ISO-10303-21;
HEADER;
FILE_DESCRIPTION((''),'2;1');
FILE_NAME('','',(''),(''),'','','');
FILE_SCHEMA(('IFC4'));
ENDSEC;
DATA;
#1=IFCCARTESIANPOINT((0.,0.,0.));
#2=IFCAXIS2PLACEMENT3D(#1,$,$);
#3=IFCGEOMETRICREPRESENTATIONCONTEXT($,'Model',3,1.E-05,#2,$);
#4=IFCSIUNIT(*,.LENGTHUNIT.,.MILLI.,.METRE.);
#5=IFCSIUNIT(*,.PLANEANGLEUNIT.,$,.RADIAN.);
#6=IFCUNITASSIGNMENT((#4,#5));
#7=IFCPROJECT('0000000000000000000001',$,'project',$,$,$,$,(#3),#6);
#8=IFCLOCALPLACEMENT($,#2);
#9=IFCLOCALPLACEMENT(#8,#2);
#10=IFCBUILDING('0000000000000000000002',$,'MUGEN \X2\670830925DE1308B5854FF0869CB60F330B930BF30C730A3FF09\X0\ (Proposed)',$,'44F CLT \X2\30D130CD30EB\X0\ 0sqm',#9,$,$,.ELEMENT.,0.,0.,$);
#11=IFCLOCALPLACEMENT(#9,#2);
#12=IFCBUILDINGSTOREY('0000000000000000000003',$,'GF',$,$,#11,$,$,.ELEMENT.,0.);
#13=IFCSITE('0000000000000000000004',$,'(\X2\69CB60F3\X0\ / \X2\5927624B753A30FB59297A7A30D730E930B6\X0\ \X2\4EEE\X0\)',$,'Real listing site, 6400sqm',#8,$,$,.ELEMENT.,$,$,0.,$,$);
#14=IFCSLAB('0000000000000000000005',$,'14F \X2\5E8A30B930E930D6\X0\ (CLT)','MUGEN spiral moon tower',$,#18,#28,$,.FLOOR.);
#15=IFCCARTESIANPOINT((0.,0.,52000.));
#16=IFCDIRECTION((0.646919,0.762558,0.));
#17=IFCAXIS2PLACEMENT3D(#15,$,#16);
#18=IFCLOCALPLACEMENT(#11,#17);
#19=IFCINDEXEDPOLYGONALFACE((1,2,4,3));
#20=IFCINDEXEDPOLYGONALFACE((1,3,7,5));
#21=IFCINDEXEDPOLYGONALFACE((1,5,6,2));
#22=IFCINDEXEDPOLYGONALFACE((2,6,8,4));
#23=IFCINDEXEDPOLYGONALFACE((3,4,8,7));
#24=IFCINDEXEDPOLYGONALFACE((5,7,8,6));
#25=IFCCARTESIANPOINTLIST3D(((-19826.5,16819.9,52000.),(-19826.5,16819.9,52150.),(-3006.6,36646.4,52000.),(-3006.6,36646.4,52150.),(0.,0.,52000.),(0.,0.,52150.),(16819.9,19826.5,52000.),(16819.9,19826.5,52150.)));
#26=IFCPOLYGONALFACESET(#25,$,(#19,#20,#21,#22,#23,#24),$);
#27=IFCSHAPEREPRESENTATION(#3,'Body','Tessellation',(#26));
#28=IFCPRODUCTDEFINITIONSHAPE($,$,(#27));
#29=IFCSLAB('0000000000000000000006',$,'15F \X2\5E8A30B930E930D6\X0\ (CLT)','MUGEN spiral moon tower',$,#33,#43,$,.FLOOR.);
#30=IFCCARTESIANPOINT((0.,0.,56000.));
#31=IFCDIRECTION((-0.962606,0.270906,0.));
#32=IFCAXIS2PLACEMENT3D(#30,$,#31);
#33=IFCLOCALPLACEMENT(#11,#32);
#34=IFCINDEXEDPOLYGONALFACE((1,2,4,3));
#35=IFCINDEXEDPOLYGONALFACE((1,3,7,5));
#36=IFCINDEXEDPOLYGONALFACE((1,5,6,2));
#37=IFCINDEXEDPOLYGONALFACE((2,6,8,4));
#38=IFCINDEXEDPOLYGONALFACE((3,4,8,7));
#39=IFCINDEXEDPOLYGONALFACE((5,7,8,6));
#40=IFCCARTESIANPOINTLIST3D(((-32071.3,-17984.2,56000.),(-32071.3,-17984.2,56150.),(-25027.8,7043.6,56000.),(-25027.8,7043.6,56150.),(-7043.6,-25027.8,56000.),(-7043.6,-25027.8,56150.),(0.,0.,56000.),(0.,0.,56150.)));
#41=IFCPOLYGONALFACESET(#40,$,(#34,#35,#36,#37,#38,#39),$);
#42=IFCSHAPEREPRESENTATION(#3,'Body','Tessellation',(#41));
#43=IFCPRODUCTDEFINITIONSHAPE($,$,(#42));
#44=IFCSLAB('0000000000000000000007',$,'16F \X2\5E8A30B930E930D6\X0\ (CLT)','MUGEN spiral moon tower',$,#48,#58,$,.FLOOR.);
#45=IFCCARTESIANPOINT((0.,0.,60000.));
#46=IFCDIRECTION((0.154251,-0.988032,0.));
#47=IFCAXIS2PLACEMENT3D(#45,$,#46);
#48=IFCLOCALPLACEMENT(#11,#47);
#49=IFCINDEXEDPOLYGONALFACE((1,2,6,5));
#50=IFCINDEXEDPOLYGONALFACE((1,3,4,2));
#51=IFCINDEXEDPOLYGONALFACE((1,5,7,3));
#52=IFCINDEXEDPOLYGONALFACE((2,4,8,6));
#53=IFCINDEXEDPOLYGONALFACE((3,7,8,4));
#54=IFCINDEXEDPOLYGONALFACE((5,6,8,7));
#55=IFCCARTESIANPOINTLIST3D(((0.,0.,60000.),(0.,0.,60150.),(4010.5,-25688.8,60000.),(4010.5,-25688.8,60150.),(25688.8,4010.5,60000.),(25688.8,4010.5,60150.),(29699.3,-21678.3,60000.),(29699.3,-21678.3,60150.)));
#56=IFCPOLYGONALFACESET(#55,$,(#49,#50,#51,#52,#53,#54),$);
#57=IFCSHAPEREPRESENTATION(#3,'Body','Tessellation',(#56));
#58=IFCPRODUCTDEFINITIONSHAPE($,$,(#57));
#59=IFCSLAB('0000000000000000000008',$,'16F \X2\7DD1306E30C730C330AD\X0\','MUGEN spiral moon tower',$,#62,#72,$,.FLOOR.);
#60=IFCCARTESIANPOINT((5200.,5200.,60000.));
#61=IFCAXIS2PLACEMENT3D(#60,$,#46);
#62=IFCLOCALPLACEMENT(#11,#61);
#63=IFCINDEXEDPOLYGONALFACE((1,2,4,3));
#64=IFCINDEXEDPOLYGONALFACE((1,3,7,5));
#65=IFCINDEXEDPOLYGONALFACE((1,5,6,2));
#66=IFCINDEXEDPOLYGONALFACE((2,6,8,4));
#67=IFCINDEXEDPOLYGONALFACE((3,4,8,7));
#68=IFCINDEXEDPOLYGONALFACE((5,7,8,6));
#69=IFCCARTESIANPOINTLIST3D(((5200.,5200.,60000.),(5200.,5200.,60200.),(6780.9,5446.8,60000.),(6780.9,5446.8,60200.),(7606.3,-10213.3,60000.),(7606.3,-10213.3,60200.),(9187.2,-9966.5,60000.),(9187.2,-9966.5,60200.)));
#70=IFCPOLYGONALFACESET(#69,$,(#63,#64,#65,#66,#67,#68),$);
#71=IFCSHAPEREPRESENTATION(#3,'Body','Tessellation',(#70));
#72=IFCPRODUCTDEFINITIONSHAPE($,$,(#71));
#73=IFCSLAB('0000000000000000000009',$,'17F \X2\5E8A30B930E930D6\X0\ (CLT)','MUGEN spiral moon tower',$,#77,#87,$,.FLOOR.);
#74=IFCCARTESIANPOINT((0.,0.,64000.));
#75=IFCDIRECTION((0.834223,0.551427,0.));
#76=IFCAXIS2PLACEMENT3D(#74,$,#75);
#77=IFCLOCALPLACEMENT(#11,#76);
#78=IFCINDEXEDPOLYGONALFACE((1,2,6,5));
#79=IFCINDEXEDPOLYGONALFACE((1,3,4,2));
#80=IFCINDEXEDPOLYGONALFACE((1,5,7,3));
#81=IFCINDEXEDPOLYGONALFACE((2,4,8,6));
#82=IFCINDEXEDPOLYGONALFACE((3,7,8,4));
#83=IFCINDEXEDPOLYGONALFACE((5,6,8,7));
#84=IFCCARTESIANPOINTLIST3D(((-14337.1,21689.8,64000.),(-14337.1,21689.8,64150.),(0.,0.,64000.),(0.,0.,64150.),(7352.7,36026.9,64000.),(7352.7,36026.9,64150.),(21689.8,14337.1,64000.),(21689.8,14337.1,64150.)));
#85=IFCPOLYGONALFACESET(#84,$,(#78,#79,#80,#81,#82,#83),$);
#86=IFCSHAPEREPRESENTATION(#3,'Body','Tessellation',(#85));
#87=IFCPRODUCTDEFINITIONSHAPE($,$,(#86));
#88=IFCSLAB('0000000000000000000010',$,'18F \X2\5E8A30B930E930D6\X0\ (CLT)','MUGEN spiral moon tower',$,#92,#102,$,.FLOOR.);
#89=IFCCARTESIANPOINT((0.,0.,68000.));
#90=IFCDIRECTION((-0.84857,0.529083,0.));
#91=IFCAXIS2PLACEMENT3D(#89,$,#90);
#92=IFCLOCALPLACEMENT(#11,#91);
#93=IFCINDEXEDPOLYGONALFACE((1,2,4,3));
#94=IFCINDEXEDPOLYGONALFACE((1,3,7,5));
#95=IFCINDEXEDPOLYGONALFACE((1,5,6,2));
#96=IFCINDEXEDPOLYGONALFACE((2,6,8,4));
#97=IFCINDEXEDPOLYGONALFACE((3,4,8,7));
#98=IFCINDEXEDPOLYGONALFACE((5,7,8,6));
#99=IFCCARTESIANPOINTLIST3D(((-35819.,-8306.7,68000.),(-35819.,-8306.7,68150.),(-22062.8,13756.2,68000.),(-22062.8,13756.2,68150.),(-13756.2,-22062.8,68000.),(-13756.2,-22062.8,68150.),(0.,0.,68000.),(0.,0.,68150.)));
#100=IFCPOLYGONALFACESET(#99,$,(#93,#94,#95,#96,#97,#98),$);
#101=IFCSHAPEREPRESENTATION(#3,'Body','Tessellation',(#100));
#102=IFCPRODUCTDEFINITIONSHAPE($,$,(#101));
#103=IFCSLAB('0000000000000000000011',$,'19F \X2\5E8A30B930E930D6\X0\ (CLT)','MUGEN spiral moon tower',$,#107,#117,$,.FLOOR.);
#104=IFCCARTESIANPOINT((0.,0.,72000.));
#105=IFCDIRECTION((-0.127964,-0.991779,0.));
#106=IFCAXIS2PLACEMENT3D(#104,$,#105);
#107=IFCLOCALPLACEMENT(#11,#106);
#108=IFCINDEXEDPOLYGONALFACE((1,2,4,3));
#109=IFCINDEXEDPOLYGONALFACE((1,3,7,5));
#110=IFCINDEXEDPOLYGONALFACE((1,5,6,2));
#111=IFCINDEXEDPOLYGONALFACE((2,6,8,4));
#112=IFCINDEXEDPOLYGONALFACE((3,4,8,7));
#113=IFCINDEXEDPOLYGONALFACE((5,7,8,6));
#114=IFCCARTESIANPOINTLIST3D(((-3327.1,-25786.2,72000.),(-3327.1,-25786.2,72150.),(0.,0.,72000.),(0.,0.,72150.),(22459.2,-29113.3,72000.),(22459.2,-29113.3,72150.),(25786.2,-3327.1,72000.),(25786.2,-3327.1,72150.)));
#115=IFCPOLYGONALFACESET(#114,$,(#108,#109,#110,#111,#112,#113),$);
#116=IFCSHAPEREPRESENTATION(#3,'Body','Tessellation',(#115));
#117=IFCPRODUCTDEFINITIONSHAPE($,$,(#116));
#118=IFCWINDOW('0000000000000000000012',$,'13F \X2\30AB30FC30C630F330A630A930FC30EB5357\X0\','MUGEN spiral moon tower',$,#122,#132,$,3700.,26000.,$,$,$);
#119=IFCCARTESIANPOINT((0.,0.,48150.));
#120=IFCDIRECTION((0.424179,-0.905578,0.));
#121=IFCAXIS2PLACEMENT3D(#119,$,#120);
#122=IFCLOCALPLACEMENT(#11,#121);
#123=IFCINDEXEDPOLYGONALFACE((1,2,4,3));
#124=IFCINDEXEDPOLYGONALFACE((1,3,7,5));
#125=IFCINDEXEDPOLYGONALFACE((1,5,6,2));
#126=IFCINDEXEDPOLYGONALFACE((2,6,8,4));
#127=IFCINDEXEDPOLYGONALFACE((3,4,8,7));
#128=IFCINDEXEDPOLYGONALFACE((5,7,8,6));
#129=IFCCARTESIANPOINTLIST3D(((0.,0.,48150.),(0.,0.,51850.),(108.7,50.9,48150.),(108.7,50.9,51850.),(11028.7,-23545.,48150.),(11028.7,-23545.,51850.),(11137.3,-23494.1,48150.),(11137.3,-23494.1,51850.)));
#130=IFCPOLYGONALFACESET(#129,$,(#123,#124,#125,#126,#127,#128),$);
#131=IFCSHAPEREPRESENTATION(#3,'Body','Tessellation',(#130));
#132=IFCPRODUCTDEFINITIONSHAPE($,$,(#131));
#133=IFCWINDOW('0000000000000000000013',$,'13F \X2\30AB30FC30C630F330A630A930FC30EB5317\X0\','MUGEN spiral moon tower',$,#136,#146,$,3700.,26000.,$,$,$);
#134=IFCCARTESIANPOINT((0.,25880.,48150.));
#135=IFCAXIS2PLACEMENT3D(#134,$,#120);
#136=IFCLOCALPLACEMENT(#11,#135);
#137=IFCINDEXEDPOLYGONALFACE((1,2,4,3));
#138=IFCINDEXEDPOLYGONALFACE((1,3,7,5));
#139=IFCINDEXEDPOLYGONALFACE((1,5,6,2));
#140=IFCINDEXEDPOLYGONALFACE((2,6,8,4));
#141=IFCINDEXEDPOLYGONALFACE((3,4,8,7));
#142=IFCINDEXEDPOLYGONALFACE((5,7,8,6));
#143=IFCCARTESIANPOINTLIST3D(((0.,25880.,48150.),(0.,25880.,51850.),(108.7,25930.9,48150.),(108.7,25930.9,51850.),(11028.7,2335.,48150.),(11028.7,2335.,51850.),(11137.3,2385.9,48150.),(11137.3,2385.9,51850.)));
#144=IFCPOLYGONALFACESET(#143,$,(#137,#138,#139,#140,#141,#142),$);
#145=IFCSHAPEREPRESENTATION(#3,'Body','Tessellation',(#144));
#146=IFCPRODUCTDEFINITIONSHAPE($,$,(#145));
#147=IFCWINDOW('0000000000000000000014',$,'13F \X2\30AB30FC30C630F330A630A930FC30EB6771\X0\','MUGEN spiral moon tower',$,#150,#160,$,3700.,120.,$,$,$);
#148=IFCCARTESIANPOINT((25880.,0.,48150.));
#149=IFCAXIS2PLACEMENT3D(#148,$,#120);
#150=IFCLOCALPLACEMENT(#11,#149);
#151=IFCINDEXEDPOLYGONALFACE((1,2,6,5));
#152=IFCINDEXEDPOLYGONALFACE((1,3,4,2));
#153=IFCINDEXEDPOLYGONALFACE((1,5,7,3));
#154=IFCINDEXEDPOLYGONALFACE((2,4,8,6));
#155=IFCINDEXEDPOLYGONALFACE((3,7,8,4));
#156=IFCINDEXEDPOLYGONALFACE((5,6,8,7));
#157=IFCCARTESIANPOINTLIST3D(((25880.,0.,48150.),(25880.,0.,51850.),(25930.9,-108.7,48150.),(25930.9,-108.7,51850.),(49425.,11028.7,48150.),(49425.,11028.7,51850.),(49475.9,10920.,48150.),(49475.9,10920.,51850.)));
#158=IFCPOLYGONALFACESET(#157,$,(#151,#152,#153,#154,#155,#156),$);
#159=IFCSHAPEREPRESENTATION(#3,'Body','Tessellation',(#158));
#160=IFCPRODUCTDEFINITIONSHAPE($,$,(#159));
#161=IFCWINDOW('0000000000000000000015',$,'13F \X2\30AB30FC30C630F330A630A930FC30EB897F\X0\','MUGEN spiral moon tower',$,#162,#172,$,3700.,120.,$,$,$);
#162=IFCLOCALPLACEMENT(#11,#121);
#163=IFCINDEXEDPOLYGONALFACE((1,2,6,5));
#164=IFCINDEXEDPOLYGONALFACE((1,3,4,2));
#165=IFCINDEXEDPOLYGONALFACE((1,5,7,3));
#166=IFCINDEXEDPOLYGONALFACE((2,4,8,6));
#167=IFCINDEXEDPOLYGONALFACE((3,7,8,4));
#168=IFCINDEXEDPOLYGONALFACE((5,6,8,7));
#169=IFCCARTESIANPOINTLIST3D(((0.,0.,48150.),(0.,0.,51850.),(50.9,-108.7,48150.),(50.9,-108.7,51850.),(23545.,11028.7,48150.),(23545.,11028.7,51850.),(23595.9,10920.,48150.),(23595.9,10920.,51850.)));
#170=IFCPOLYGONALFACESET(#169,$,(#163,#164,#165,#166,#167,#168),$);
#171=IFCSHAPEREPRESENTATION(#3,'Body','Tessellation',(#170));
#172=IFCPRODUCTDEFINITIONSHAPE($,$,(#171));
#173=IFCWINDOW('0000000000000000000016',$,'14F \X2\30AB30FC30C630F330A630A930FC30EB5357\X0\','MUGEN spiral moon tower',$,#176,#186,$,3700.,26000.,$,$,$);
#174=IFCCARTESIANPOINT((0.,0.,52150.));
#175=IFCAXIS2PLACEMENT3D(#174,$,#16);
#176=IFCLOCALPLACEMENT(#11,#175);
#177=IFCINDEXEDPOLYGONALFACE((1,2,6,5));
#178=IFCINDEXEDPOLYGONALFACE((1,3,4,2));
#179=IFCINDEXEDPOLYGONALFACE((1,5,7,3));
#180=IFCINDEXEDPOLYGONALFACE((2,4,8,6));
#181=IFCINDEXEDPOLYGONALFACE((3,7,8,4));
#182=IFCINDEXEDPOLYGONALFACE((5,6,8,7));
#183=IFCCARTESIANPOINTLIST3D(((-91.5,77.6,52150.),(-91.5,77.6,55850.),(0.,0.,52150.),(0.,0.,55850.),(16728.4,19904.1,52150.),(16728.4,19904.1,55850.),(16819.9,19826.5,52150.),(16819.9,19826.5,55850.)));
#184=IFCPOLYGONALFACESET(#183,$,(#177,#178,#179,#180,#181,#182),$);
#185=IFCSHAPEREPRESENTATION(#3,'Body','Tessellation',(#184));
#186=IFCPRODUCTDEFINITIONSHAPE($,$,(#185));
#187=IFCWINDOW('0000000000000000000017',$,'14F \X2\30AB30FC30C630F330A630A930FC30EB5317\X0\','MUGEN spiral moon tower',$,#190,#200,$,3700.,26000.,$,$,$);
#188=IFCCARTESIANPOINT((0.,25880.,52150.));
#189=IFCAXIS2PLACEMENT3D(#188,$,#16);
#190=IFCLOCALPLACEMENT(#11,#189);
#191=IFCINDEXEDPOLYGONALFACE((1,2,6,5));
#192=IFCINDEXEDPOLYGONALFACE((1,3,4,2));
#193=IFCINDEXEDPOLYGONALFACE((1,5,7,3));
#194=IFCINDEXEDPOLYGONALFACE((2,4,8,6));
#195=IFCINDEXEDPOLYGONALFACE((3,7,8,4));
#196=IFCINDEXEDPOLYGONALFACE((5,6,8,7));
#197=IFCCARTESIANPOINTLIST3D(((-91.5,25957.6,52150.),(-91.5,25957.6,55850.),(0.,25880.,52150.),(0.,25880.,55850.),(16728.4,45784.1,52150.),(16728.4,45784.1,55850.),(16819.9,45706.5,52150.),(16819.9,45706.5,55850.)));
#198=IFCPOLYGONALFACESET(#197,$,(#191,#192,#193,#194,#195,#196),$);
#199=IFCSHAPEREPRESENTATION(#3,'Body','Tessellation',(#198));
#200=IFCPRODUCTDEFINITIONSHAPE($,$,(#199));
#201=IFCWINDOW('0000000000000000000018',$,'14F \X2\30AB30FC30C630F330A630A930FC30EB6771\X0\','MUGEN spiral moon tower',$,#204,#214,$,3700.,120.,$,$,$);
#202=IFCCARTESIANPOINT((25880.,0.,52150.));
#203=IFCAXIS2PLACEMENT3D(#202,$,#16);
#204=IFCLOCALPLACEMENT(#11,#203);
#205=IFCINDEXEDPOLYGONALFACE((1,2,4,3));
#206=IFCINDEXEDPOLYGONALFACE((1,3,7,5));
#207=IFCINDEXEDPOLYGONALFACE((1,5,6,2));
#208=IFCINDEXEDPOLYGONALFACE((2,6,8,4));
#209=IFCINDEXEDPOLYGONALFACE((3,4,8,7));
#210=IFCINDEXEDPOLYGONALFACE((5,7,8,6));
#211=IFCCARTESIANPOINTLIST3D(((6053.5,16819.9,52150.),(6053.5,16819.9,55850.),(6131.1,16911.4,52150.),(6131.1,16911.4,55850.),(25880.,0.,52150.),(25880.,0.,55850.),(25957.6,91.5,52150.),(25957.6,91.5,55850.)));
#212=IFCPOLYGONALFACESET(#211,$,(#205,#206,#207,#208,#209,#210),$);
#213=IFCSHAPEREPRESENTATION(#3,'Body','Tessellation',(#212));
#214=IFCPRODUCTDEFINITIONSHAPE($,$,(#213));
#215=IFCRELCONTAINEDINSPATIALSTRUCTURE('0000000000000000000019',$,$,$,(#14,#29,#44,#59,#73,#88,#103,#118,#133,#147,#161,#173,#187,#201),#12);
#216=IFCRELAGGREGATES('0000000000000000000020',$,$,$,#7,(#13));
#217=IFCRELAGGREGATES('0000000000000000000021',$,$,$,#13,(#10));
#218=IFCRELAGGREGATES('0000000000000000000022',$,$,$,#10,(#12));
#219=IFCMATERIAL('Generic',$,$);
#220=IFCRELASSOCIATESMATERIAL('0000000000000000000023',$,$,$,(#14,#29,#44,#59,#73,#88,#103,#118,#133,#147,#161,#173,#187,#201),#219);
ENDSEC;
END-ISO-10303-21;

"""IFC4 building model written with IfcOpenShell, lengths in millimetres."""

from ifc_helpers import new_model, si_unit, frame, frame_2d, origin, place, context, project, spatial, rectangle, extrude, material, element, save


model = new_model("IFC4")

# Units and contexts
model_context = context("Model", 3, precision=1e-05, world=origin())
ifc_project = project(units=[si_unit("LENGTHUNIT", "METRE", prefix="MILLI"), si_unit("PLANEANGLEUNIT", "RADIAN")], contexts=[model_context])

# Site, building, storey
site_placement = place(None, origin())
site = spatial("IfcSite", under=ifc_project, at=site_placement, Name="(構想 / 大手町・天空プラザ 仮)", ObjectType="Real listing site, 6400sqm", CompositionType="ELEMENT", RefElevation=0.0)
building_placement = place(site_placement, origin())
building = spatial("IfcBuilding", under=site, at=building_placement, Name="MUGEN 月を巡る塔（構想スタディ） (Proposed)", ObjectType="44F CLT パネル 0sqm", CompositionType="ELEMENT", ElevationOfRefHeight=0.0, ElevationOfTerrain=0.0)
storey_placement = place(building_placement, origin())
storey = spatial("IfcBuildingStorey", under=building, at=storey_placement, Name="GF", CompositionType="ELEMENT", Elevation=0.0)

# Slabs
ifc_material = material(Name="Generic")
slab_1_placement = place(storey_placement, frame((0.0, 0.0, 52000.0), x_axis=(0.646919, 0.762558, 0.0)))
element("IfcSlab", 1, at=slab_1_placement, inside=storey, material=ifc_material, Name="14F 床スラブ (CLT)", Description="MUGEN spiral moon tower", PredefinedType="FLOOR", context=model_context, shape_type="SweptSolid", body=[
    extrude(rectangle(XDim=26000.0, YDim=26000.0, at=frame_2d((13000.0, 13000.0))), frame((0.0, 0.0, 52000.0), x_axis=(0.646919, 0.762558, 0.0)), (0.0, 0.0, 1.0), 150.0),
])
slab_2_placement = place(storey_placement, frame((0.0, 0.0, 56000.0), x_axis=(-0.962606, 0.270906, 0.0)))
element("IfcSlab", 2, at=slab_2_placement, inside=storey, material=ifc_material, Name="15F 床スラブ (CLT)", Description="MUGEN spiral moon tower", PredefinedType="FLOOR", context=model_context, shape_type="SweptSolid", body=[
    extrude(rectangle(XDim=26000.0, YDim=26000.0, at=frame_2d((13000.0, 13000.0))), frame((0.0, 0.0, 56000.0), x_axis=(-0.962606, 0.270906, 0.0)), (0.0, 0.0, 1.0), 150.0),
])
slab_3_placement = place(storey_placement, frame((0.0, 0.0, 60000.0), x_axis=(0.154251, -0.988032, 0.0)))
element("IfcSlab", 3, at=slab_3_placement, inside=storey, material=ifc_material, Name="16F 床スラブ (CLT)", Description="MUGEN spiral moon tower", PredefinedType="FLOOR", context=model_context, shape_type="SweptSolid", body=[
    extrude(rectangle(XDim=26000.0, YDim=26000.0, at=frame_2d((13000.0, 13000.0))), frame((0.0, 0.0, 60000.0), x_axis=(0.154251, -0.988032, 0.0)), (0.0, 0.0, 1.0), 150.0),
])
slab_4_placement = place(storey_placement, frame((5200.0, 5200.0, 60000.0), x_axis=(0.154251, -0.988032, 0.0)))
element("IfcSlab", 4, at=slab_4_placement, inside=storey, material=ifc_material, Name="16F 緑のデッキ", Description="MUGEN spiral moon tower", PredefinedType="FLOOR", context=model_context, shape_type="SweptSolid", body=[
    extrude(rectangle(XDim=15600.0, YDim=1600.0, at=frame_2d((7800.0, 800.0))), frame((5200.0, 5200.0, 60000.0), x_axis=(0.154251, -0.988032, 0.0)), (0.0, 0.0, 1.0), 200.0),
])
slab_5_placement = place(storey_placement, frame((0.0, 0.0, 64000.0), x_axis=(0.834223, 0.551427, 0.0)))
element("IfcSlab", 5, at=slab_5_placement, inside=storey, material=ifc_material, Name="17F 床スラブ (CLT)", Description="MUGEN spiral moon tower", PredefinedType="FLOOR", context=model_context, shape_type="SweptSolid", body=[
    extrude(rectangle(XDim=26000.0, YDim=26000.0, at=frame_2d((13000.0, 13000.0))), frame((0.0, 0.0, 64000.0), x_axis=(0.834223, 0.551427, 0.0)), (0.0, 0.0, 1.0), 150.0),
])
slab_6_placement = place(storey_placement, frame((0.0, 0.0, 68000.0), x_axis=(-0.84857, 0.529083, 0.0)))
element("IfcSlab", 6, at=slab_6_placement, inside=storey, material=ifc_material, Name="18F 床スラブ (CLT)", Description="MUGEN spiral moon tower", PredefinedType="FLOOR", context=model_context, shape_type="SweptSolid", body=[
    extrude(rectangle(XDim=26000.0, YDim=26000.0, at=frame_2d((13000.0, 13000.0))), frame((0.0, 0.0, 68000.0), x_axis=(-0.84857, 0.529083, 0.0)), (0.0, 0.0, 1.0), 150.0),
])
slab_7_placement = place(storey_placement, frame((0.0, 0.0, 72000.0), x_axis=(-0.127964, -0.991779, 0.0)))
element("IfcSlab", 7, at=slab_7_placement, inside=storey, material=ifc_material, Name="19F 床スラブ (CLT)", Description="MUGEN spiral moon tower", PredefinedType="FLOOR", context=model_context, shape_type="SweptSolid", body=[
    extrude(rectangle(XDim=26000.0, YDim=26000.0, at=frame_2d((13000.0, 13000.0))), frame((0.0, 0.0, 72000.0), x_axis=(-0.127964, -0.991779, 0.0)), (0.0, 0.0, 1.0), 150.0),
])

# Windows
window_1_placement = place(storey_placement, frame((0.0, 0.0, 48150.0), x_axis=(0.424179, -0.905578, 0.0)))
element("IfcWindow", 8, at=window_1_placement, inside=storey, material=ifc_material, Name="13F カーテンウォール南", Description="MUGEN spiral moon tower", OverallHeight=3700.0, OverallWidth=26000.0, context=model_context, shape_type="SweptSolid", body=[
    extrude(rectangle(XDim=26000.0, YDim=120.0, at=frame_2d((13000.0, 60.0))), frame((0.0, 0.0, 48150.0), x_axis=(0.424179, -0.905578, 0.0)), (0.0, 0.0, 1.0), 3700.0),
])
window_2_placement = place(storey_placement, frame((0.0, 25880.0, 48150.0), x_axis=(0.424179, -0.905578, 0.0)))
element("IfcWindow", 9, at=window_2_placement, inside=storey, material=ifc_material, Name="13F カーテンウォール北", Description="MUGEN spiral moon tower", OverallHeight=3700.0, OverallWidth=26000.0, context=model_context, shape_type="SweptSolid", body=[
    extrude(rectangle(XDim=26000.0, YDim=120.0, at=frame_2d((13000.0, 60.0))), frame((0.0, 25880.0, 48150.0), x_axis=(0.424179, -0.905578, 0.0)), (0.0, 0.0, 1.0), 3700.0),
])
window_3_placement = place(storey_placement, frame((25880.0, 0.0, 48150.0), x_axis=(0.424179, -0.905578, 0.0)))
element("IfcWindow", 10, at=window_3_placement, inside=storey, material=ifc_material, Name="13F カーテンウォール東", Description="MUGEN spiral moon tower", OverallHeight=3700.0, OverallWidth=120.0, context=model_context, shape_type="SweptSolid", body=[
    extrude(rectangle(XDim=120.0, YDim=26000.0, at=frame_2d((60.0, 13000.0))), frame((25880.0, 0.0, 48150.0), x_axis=(0.424179, -0.905578, 0.0)), (0.0, 0.0, 1.0), 3700.0),
])
window_4_placement = place(storey_placement, frame((0.0, 0.0, 48150.0), x_axis=(0.424179, -0.905578, 0.0)))
element("IfcWindow", 11, at=window_4_placement, inside=storey, material=ifc_material, Name="13F カーテンウォール西", Description="MUGEN spiral moon tower", OverallHeight=3700.0, OverallWidth=120.0, context=model_context, shape_type="SweptSolid", body=[
    extrude(rectangle(XDim=120.0, YDim=26000.0, at=frame_2d((60.0, 13000.0))), frame((0.0, 0.0, 48150.0), x_axis=(0.424179, -0.905578, 0.0)), (0.0, 0.0, 1.0), 3700.0),
])
window_5_placement = place(storey_placement, frame((0.0, 0.0, 52150.0), x_axis=(0.646919, 0.762558, 0.0)))
element("IfcWindow", 12, at=window_5_placement, inside=storey, material=ifc_material, Name="14F カーテンウォール南", Description="MUGEN spiral moon tower", OverallHeight=3700.0, OverallWidth=26000.0, context=model_context, shape_type="SweptSolid", body=[
    extrude(rectangle(XDim=26000.0, YDim=120.0, at=frame_2d((13000.0, 60.0))), frame((0.0, 0.0, 52150.0), x_axis=(0.646919, 0.762558, 0.0)), (0.0, 0.0, 1.0), 3700.0),
])
window_6_placement = place(storey_placement, frame((0.0, 25880.0, 52150.0), x_axis=(0.646919, 0.762558, 0.0)))
element("IfcWindow", 13, at=window_6_placement, inside=storey, material=ifc_material, Name="14F カーテンウォール北", Description="MUGEN spiral moon tower", OverallHeight=3700.0, OverallWidth=26000.0, context=model_context, shape_type="SweptSolid", body=[
    extrude(rectangle(XDim=26000.0, YDim=120.0, at=frame_2d((13000.0, 60.0))), frame((0.0, 25880.0, 52150.0), x_axis=(0.646919, 0.762558, 0.0)), (0.0, 0.0, 1.0), 3700.0),
])
window_7_placement = place(storey_placement, frame((25880.0, 0.0, 52150.0), x_axis=(0.646919, 0.762558, 0.0)))
element("IfcWindow", 14, at=window_7_placement, inside=storey, material=ifc_material, Name="14F カーテンウォール東", Description="MUGEN spiral moon tower", OverallHeight=3700.0, OverallWidth=120.0, context=model_context, shape_type="SweptSolid", body=[
    extrude(rectangle(XDim=120.0, YDim=26000.0, at=frame_2d((60.0, 13000.0))), frame((25880.0, 0.0, 52150.0), x_axis=(0.646919, 0.762558, 0.0)), (0.0, 0.0, 1.0), 3700.0),
])

save(model, "model.ifc")
